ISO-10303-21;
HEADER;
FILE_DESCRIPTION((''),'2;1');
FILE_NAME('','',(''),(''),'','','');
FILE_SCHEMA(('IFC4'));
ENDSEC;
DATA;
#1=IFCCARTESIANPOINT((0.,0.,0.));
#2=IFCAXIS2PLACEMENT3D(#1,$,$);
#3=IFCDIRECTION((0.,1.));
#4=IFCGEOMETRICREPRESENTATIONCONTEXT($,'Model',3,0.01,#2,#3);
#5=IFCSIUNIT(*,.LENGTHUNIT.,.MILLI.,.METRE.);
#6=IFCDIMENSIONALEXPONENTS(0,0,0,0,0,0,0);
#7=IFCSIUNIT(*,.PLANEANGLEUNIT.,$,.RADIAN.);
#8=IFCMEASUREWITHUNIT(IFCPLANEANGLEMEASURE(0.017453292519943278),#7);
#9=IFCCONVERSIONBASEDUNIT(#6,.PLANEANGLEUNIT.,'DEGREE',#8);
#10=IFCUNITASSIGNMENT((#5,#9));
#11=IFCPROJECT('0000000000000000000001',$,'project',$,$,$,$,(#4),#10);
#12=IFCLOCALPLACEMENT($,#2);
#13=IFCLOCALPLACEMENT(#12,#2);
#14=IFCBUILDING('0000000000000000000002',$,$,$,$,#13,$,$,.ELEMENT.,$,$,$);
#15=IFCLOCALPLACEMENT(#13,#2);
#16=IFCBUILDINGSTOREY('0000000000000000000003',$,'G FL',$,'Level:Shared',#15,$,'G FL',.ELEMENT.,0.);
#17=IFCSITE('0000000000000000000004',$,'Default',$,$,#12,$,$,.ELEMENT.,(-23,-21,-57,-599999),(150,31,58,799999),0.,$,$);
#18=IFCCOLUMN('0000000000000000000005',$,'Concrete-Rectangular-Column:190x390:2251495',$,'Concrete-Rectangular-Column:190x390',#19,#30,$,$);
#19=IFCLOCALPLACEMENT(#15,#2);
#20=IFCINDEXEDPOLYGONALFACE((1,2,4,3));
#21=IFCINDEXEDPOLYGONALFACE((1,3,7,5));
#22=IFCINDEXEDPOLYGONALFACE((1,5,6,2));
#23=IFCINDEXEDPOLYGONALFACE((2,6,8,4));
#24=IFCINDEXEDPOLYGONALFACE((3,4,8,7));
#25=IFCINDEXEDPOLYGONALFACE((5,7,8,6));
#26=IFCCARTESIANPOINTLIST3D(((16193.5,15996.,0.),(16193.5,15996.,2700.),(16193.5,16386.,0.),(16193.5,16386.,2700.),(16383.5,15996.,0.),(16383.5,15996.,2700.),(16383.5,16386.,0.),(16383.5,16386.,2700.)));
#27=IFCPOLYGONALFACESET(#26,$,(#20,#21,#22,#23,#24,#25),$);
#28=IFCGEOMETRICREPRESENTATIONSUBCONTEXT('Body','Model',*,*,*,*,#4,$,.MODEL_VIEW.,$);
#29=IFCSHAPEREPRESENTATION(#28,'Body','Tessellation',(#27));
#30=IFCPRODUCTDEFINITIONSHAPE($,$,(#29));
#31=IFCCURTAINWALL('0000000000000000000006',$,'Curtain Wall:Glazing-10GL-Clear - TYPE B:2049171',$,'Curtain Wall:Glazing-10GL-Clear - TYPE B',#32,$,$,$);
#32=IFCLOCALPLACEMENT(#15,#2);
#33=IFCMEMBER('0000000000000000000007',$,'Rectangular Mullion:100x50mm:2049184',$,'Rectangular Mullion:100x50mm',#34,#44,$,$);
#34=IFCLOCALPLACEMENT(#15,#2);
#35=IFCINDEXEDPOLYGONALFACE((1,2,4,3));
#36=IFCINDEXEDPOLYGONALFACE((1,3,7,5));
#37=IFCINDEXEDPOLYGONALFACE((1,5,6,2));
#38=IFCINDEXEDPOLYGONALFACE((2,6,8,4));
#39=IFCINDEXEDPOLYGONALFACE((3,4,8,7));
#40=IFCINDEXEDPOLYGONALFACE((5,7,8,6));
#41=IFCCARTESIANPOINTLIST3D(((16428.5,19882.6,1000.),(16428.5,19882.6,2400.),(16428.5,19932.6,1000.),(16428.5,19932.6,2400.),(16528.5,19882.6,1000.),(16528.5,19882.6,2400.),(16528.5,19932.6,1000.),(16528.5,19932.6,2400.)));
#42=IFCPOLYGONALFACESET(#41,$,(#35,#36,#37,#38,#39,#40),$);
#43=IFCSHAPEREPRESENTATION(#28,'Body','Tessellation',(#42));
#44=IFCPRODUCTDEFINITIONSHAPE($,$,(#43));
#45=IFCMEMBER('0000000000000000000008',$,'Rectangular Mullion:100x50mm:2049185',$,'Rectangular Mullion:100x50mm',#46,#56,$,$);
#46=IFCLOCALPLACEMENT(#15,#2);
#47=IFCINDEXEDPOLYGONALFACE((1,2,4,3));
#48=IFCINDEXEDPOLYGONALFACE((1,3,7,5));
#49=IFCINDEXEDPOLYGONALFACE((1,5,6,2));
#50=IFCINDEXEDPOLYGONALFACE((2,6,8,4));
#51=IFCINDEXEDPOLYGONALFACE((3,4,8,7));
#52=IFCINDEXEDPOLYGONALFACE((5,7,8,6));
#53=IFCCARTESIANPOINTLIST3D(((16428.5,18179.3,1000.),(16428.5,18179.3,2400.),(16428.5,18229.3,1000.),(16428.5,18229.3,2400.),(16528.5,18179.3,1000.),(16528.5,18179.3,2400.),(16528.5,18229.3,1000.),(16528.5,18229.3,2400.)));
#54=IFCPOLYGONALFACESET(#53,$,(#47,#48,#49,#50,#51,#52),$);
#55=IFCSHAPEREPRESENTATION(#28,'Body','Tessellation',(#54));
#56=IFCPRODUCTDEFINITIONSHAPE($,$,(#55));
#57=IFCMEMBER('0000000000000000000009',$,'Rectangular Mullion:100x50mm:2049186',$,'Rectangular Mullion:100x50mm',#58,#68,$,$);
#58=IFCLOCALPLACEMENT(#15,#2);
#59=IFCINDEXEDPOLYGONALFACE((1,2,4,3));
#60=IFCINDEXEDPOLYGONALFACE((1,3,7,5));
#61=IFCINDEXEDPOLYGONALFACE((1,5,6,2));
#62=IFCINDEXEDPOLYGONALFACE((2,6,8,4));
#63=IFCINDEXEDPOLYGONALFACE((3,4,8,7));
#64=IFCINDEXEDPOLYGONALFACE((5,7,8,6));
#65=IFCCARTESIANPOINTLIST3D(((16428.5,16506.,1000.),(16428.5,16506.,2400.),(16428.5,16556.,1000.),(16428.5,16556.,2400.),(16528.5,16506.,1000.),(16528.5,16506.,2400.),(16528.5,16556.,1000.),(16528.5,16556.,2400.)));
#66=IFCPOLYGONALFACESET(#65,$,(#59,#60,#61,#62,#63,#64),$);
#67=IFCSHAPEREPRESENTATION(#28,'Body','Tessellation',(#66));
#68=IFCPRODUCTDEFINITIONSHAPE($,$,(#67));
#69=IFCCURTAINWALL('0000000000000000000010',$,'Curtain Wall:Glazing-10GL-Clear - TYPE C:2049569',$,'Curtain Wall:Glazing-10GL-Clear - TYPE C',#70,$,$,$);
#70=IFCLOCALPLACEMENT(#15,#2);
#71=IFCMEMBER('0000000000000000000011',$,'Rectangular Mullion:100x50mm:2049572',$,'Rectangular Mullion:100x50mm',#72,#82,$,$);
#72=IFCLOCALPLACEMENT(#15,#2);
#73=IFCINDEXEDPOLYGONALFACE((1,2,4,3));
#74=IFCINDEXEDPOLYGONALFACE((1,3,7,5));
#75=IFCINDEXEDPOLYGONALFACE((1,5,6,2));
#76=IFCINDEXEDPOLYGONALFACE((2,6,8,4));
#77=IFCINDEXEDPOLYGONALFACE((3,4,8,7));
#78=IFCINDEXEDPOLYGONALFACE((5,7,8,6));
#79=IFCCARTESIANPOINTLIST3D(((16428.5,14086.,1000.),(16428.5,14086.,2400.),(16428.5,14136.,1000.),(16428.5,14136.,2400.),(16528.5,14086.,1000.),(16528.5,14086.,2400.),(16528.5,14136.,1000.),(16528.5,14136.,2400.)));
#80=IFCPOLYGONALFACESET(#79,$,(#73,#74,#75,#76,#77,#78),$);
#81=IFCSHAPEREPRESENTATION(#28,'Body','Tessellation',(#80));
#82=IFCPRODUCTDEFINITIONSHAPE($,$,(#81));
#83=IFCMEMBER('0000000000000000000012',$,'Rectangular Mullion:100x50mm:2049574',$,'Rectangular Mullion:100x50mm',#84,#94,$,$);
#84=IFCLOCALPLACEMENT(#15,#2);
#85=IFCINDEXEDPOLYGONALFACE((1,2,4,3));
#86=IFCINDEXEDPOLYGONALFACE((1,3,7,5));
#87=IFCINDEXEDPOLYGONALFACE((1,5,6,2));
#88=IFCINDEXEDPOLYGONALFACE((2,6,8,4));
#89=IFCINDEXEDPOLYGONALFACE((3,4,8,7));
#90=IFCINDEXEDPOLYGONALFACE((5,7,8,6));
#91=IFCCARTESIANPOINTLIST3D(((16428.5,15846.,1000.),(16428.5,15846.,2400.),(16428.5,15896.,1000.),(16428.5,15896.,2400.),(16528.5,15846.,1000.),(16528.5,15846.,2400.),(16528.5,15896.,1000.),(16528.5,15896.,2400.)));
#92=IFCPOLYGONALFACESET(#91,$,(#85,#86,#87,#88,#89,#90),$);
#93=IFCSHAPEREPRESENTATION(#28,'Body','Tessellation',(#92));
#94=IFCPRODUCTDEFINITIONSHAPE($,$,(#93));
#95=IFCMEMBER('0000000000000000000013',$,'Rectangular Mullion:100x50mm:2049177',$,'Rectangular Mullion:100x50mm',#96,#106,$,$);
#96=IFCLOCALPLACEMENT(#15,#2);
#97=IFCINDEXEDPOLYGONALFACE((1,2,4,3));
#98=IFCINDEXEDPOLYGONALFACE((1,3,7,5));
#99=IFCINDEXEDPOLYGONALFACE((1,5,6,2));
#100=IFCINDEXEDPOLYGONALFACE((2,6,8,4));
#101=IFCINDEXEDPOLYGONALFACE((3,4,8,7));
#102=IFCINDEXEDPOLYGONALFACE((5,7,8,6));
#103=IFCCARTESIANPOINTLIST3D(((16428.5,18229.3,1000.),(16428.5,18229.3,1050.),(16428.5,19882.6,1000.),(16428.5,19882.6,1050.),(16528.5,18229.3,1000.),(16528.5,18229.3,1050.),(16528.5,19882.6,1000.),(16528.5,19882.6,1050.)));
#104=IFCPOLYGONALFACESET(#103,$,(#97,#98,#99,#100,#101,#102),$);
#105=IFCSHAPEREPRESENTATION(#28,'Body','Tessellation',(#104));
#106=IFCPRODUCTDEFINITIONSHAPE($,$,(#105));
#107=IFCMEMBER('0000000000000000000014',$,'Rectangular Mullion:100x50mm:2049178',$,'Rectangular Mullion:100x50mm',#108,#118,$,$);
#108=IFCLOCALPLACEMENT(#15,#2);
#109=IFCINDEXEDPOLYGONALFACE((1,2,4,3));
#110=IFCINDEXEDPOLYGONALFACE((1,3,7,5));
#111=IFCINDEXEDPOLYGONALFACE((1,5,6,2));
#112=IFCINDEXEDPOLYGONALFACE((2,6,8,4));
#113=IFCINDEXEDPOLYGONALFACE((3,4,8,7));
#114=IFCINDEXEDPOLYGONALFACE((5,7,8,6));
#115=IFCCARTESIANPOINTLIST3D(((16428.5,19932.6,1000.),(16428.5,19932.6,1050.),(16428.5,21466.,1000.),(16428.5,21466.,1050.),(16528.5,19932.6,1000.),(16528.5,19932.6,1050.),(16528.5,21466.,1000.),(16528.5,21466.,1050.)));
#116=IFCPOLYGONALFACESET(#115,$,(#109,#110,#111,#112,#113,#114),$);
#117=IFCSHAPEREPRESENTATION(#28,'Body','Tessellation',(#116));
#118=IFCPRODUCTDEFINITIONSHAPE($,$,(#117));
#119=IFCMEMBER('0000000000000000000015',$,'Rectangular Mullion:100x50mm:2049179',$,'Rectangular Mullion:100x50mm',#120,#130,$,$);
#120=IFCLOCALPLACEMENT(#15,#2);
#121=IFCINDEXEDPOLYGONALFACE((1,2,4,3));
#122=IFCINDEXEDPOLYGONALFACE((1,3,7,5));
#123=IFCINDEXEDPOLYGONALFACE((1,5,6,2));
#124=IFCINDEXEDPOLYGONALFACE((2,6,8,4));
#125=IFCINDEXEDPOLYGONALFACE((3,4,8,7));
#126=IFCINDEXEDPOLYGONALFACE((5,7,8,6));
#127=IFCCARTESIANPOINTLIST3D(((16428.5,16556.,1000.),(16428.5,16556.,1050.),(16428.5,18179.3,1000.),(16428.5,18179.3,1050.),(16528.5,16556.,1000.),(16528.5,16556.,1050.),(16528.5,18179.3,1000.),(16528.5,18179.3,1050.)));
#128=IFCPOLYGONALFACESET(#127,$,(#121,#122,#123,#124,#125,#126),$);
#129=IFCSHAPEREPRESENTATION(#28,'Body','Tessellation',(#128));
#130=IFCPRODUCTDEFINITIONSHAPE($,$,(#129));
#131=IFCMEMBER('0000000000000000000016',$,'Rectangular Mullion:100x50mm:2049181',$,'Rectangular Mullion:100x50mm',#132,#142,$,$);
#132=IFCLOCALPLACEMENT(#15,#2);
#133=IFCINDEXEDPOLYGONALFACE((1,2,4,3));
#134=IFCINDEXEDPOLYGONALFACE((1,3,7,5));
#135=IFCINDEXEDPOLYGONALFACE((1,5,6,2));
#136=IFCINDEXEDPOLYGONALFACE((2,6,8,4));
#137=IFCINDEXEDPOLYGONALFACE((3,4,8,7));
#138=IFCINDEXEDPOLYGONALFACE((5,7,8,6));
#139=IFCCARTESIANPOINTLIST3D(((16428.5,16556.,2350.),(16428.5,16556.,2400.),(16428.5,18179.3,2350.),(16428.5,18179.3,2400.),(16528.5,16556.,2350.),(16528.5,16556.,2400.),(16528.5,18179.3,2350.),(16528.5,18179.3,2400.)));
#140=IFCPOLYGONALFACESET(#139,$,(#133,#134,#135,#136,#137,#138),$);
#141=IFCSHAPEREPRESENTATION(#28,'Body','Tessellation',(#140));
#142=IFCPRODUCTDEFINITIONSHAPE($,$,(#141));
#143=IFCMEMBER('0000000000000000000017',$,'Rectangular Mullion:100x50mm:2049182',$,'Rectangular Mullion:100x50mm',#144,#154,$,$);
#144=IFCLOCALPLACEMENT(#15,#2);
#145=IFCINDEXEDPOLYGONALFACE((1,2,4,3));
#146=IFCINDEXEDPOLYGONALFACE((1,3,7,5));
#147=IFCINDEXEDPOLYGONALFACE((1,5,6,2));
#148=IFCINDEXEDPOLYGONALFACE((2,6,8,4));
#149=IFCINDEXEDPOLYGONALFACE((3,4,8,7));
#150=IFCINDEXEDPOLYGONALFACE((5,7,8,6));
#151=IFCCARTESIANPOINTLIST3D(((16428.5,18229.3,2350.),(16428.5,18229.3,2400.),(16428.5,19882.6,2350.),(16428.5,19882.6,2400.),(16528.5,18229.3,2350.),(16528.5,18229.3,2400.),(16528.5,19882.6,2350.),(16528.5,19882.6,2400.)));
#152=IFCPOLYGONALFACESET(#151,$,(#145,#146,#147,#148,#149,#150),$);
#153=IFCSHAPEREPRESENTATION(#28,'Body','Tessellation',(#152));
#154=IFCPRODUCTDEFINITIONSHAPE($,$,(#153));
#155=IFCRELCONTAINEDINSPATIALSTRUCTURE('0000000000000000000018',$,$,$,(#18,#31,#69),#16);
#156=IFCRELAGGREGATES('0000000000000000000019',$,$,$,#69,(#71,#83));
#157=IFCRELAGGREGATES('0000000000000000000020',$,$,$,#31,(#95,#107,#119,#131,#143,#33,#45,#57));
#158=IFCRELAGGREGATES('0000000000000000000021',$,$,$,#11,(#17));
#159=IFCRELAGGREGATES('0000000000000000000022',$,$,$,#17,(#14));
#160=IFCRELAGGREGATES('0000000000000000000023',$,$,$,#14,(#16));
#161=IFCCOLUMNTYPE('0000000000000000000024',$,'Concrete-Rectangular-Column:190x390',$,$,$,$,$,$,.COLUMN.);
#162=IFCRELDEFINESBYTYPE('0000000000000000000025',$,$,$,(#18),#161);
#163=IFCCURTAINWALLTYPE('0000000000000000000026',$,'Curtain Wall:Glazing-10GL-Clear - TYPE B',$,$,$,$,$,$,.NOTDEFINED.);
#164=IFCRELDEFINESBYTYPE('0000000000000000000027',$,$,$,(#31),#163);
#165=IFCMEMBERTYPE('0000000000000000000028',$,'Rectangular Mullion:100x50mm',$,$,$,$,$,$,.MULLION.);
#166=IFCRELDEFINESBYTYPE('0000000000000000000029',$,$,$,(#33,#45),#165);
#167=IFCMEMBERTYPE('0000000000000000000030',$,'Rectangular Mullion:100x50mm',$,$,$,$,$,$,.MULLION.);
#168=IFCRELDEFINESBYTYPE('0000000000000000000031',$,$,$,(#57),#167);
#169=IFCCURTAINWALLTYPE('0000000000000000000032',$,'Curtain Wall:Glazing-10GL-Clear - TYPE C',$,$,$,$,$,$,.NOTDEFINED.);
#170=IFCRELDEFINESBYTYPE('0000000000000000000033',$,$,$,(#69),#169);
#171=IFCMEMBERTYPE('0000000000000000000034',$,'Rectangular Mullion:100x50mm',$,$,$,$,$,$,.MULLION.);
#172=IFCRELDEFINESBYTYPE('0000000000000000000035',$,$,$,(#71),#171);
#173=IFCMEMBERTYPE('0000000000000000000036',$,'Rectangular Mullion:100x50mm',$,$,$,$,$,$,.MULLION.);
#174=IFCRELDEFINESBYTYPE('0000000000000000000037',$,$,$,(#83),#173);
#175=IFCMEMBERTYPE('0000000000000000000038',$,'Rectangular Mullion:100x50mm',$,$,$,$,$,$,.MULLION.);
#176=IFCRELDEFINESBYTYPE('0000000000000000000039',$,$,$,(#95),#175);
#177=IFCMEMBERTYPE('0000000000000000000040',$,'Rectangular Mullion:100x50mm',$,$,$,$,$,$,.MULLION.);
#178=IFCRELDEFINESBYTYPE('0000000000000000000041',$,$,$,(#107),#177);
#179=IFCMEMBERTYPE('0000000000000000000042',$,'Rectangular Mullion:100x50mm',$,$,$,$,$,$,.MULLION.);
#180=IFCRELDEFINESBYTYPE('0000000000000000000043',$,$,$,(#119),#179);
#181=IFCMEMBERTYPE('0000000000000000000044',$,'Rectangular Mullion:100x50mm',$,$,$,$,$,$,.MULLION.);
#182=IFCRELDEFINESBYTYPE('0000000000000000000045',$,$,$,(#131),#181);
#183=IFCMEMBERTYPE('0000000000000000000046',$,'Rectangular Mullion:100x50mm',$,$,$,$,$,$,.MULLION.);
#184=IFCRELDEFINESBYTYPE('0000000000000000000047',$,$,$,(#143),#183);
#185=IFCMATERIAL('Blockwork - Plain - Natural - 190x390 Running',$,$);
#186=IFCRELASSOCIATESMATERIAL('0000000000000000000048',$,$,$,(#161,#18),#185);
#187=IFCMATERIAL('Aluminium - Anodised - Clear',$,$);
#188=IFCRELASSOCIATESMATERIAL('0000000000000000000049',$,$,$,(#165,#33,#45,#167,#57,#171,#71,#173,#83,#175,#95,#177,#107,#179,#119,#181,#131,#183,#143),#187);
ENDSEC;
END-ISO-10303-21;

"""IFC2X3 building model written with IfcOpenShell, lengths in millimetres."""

from ifc_helpers import new_model, entity, si_unit, converted_unit, direction, frame, frame_2d, origin, origin_2d_with_axis, place, context, subcontext, project, spatial, rectangle, extrude, source, transform, mapped, material, type_object, type_shapes, element, aggregate, save


model = new_model("IFC2X3")

# Units and contexts
model_context = context("Model", 3, precision=0.01, world=origin(), true_north=direction((0.0, 1.0)))
body_context = subcontext(model_context, "Body", "Model", "MODEL_VIEW")
ifc_project = project(units=[si_unit("LENGTHUNIT", "METRE", prefix="MILLI"), converted_unit("PLANEANGLEUNIT", "DEGREE", entity("IfcPlaneAngleMeasure", 0.017453292519943278), si_unit("PLANEANGLEUNIT", "RADIAN"), dimensions=[0, 0, 0, 0, 0, 0, 0])], contexts=[model_context])

# Site, building, storey
site_placement = place(None, origin())
site = spatial("IfcSite", under=ifc_project, at=site_placement, Name="Default", CompositionType="ELEMENT", RefLatitude=(-23, -21, -57, -599999), RefLongitude=(150, 31, 58, 799999), RefElevation=0.0)
building_placement = place(site_placement, origin())
building = spatial("IfcBuilding", under=site, at=building_placement, CompositionType="ELEMENT")
storey_placement = place(building_placement, origin())
storey = spatial("IfcBuildingStorey", under=building, at=storey_placement, Name="G FL", ObjectType="Level:Shared", LongName="G FL", CompositionType="ELEMENT", Elevation=0.0)

# Column
ifc_material_1 = material(Name="Blockwork - Plain - Natural - 190x390 Running")
column_type = type_object("IfcColumnType", Name="Concrete-Rectangular-Column:190x390", PredefinedType="COLUMN", material=ifc_material_1)
shared_shape_1 = source(origin(), body_context, "Body", "SweptSolid", [
    extrude(rectangle(XDim=190.0, YDim=390.0, at=origin_2d_with_axis()), frame((0.0, 0.0, 0.0), z_axis=(0.0, 0.0, 1.0), x_axis=(-1.0, 0.0, 0.0)), (0.0, 0.0, 1.0), 2700.0),
])
type_shapes(column_type, [shared_shape_1])
column_placement = place(storey_placement, frame((16288.5, 16191.0, 0.0)))
element("IfcColumn", 1, at=column_placement, inside=storey, type_object=column_type, material=ifc_material_1, Name="Concrete-Rectangular-Column:190x390:2251495", ObjectType="Concrete-Rectangular-Column:190x390", context=body_context, shape_type="MappedRepresentation", body=[
    mapped(shared_shape_1, transform((0.0, 0.0, 0.0), scale=1.0)),
])

# Curtain walls, members
curtain_wall_type_1 = type_object("IfcCurtainWallType", Name="Curtain Wall:Glazing-10GL-Clear - TYPE B", PredefinedType="NOTDEFINED")
curtain_wall_1_placement = place(storey_placement, origin())
curtain_wall_1 = element("IfcCurtainWall", 2, at=curtain_wall_1_placement, inside=storey, type_object=curtain_wall_type_1, Name="Curtain Wall:Glazing-10GL-Clear - TYPE B:2049171", ObjectType="Curtain Wall:Glazing-10GL-Clear - TYPE B")
ifc_material_2 = material(Name="Aluminium - Anodised - Clear")
member_type_1 = type_object("IfcMemberType", Name="Rectangular Mullion:100x50mm", PredefinedType="MULLION", material=ifc_material_2)
shared_shape_2 = source(origin(), body_context, "Body", "SweptSolid", [
    extrude(rectangle(XDim=50.0, YDim=100.0, at=frame_2d((0.0, 0.0), x_axis=(1.0, 0.0))), frame((0.0, 0.0, -1400.0), z_axis=(0.0, 0.0, 1.0), x_axis=(-1.0, 0.0, 0.0)), (0.0, 0.0, 1.0), 1400.0),
])
type_shapes(member_type_1, [shared_shape_2])
member_1_placement = place(curtain_wall_1_placement, frame((16478.5, 19907.6, 1000.0), z_axis=(0.0, 0.0, -1.0), x_axis=(0.0, 1.0, 0.0)))
member_1 = element("IfcMember", 3, at=member_1_placement, type_object=member_type_1, material=ifc_material_2, Name="Rectangular Mullion:100x50mm:2049184", ObjectType="Rectangular Mullion:100x50mm", context=body_context, shape_type="MappedRepresentation", body=[
    mapped(shared_shape_2, transform((0.0, 0.0, 0.0), scale=1.0)),
])
member_2_placement = place(curtain_wall_1_placement, frame((16478.5, 18204.3, 1000.0), z_axis=(0.0, 0.0, -1.0), x_axis=(0.0, 1.0, 0.0)))
member_2 = element("IfcMember", 4, at=member_2_placement, type_object=member_type_1, material=ifc_material_2, Name="Rectangular Mullion:100x50mm:2049185", ObjectType="Rectangular Mullion:100x50mm", context=body_context, shape_type="MappedRepresentation", body=[
    mapped(shared_shape_2, transform((0.0, 0.0, 0.0), scale=1.0)),
])
member_type_2 = type_object("IfcMemberType", Name="Rectangular Mullion:100x50mm", PredefinedType="MULLION", material=ifc_material_2)
shared_shape_3 = source(origin(), body_context, "Body", "SweptSolid", [
    extrude(rectangle(XDim=50.0, YDim=100.0, at=frame_2d((0.0, 0.0), x_axis=(1.0, 0.0))), frame((-25.0, 0.0, -1400.0), z_axis=(0.0, 0.0, 1.0), x_axis=(-1.0, 0.0, 0.0)), (0.0, 0.0, 1.0), 1400.0),
])
type_shapes(member_type_2, [shared_shape_3])
member_3_placement = place(curtain_wall_1_placement, frame((16478.5, 16506.0, 2400.0), z_axis=(0.0, 0.0, 1.0), x_axis=(0.0, -1.0, 0.0)))
member_3 = element("IfcMember", 5, at=member_3_placement, type_object=member_type_2, material=ifc_material_2, Name="Rectangular Mullion:100x50mm:2049186", ObjectType="Rectangular Mullion:100x50mm", context=body_context, shape_type="MappedRepresentation", body=[
    mapped(shared_shape_3, transform((0.0, 0.0, 0.0), scale=1.0)),
])
curtain_wall_type_2 = type_object("IfcCurtainWallType", Name="Curtain Wall:Glazing-10GL-Clear - TYPE C", PredefinedType="NOTDEFINED")
curtain_wall_2_placement = place(storey_placement, origin())
curtain_wall_2 = element("IfcCurtainWall", 6, at=curtain_wall_2_placement, inside=storey, type_object=curtain_wall_type_2, Name="Curtain Wall:Glazing-10GL-Clear - TYPE C:2049569", ObjectType="Curtain Wall:Glazing-10GL-Clear - TYPE C")
member_type_3 = type_object("IfcMemberType", Name="Rectangular Mullion:100x50mm", PredefinedType="MULLION", material=ifc_material_2)
shared_shape_4 = source(origin(), body_context, "Body", "SweptSolid", [
    extrude(rectangle(XDim=50.0, YDim=100.0, at=frame_2d((0.0, 0.0), x_axis=(1.0, 0.0))), frame((-25.0, 0.0, -1400.0), z_axis=(0.0, 0.0, 1.0), x_axis=(-1.0, 0.0, 0.0)), (0.0, 0.0, 1.0), 1400.0),
])
type_shapes(member_type_3, [shared_shape_4])
member_4_placement = place(curtain_wall_2_placement, frame((16478.5, 14086.0, 1000.0), z_axis=(0.0, 0.0, -1.0), x_axis=(0.0, -1.0, 0.0)))
member_4 = element("IfcMember", 7, at=member_4_placement, type_object=member_type_3, material=ifc_material_2, Name="Rectangular Mullion:100x50mm:2049572", ObjectType="Rectangular Mullion:100x50mm", context=body_context, shape_type="MappedRepresentation", body=[
    mapped(shared_shape_4, transform((0.0, 0.0, 0.0), scale=1.0)),
])
member_type_4 = type_object("IfcMemberType", Name="Rectangular Mullion:100x50mm", PredefinedType="MULLION", material=ifc_material_2)
shared_shape_5 = source(origin(), body_context, "Body", "SweptSolid", [
    extrude(rectangle(XDim=50.0, YDim=100.0, at=origin_2d_with_axis()), frame((-25.0, 0.0, -1400.0), z_axis=(0.0, 0.0, 1.0), x_axis=(-1.0, 0.0, 0.0)), (0.0, 0.0, 1.0), 1400.0),
])
type_shapes(member_type_4, [shared_shape_5])
member_5_placement = place(curtain_wall_2_placement, frame((16478.5, 15896.0, 2400.0), z_axis=(0.0, 0.0, 1.0), x_axis=(0.0, 1.0, 0.0)))
member_5 = element("IfcMember", 8, at=member_5_placement, type_object=member_type_4, material=ifc_material_2, Name="Rectangular Mullion:100x50mm:2049574", ObjectType="Rectangular Mullion:100x50mm", context=body_context, shape_type="MappedRepresentation", body=[
    mapped(shared_shape_5, transform((0.0, 0.0, 0.0), scale=1.0)),
])

# Members
member_type_5 = type_object("IfcMemberType", Name="Rectangular Mullion:100x50mm", PredefinedType="MULLION", material=ifc_material_2)
shared_shape_6 = source(origin(), body_context, "Body", "SweptSolid", [
    extrude(rectangle(XDim=50.0, YDim=100.0, at=frame_2d((0.0, 0.0), x_axis=(1.0, 0.0))), frame((-25.0, 0.0, -1653.3), z_axis=(0.0, 0.0, 1.0), x_axis=(-1.0, 0.0, 0.0)), (0.0, 0.0, 1.0), 1653.3),
])
type_shapes(member_type_5, [shared_shape_6])
member_6_placement = place(curtain_wall_1_placement, frame((16478.5, 18229.3, 1000.0), z_axis=(0.0, -1.0, 0.0), x_axis=(0.0, 0.0, -1.0)))
member_6 = element("IfcMember", 9, at=member_6_placement, type_object=member_type_5, material=ifc_material_2, Name="Rectangular Mullion:100x50mm:2049177", ObjectType="Rectangular Mullion:100x50mm", context=body_context, shape_type="MappedRepresentation", body=[
    mapped(shared_shape_6, transform((0.0, 0.0, 0.0), scale=1.0)),
])
member_type_6 = type_object("IfcMemberType", Name="Rectangular Mullion:100x50mm", PredefinedType="MULLION", material=ifc_material_2)
shared_shape_7 = source(origin(), body_context, "Body", "SweptSolid", [
    extrude(rectangle(XDim=50.0, YDim=100.0, at=frame_2d((0.0, 0.0), x_axis=(1.0, 0.0))), frame((-25.0, 0.0, -1533.3), z_axis=(0.0, 0.0, 1.0), x_axis=(-1.0, 0.0, 0.0)), (0.0, 0.0, 1.0), 1533.3),
])
type_shapes(member_type_6, [shared_shape_7])
member_7_placement = place(curtain_wall_1_placement, frame((16478.5, 19932.6, 1000.0), z_axis=(0.0, -1.0, 0.0), x_axis=(0.0, 0.0, -1.0)))
member_7 = element("IfcMember", 10, at=member_7_placement, type_object=member_type_6, material=ifc_material_2, Name="Rectangular Mullion:100x50mm:2049178", ObjectType="Rectangular Mullion:100x50mm", context=body_context, shape_type="MappedRepresentation", body=[
    mapped(shared_shape_7, transform((0.0, 0.0, 0.0), scale=1.0)),
])
member_type_7 = type_object("IfcMemberType", Name="Rectangular Mullion:100x50mm", PredefinedType="MULLION", material=ifc_material_2)
shared_shape_8 = source(origin(), body_context, "Body", "SweptSolid", [
    extrude(rectangle(XDim=50.0, YDim=100.0, at=origin_2d_with_axis()), frame((-25.0, 0.0, -1623.3), z_axis=(0.0, 0.0, 1.0), x_axis=(-1.0, 0.0, 0.0)), (0.0, 0.0, 1.0), 1623.3),
])
type_shapes(member_type_7, [shared_shape_8])
member_8_placement = place(curtain_wall_1_placement, frame((16478.5, 16556.0, 1000.0), z_axis=(0.0, -1.0, 0.0), x_axis=(0.0, 0.0, -1.0)))
member_8 = element("IfcMember", 11, at=member_8_placement, type_object=member_type_7, material=ifc_material_2, Name="Rectangular Mullion:100x50mm:2049179", ObjectType="Rectangular Mullion:100x50mm", context=body_context, shape_type="MappedRepresentation", body=[
    mapped(shared_shape_8, transform((0.0, 0.0, 0.0), scale=1.0)),
])
member_type_8 = type_object("IfcMemberType", Name="Rectangular Mullion:100x50mm", PredefinedType="MULLION", material=ifc_material_2)
shared_shape_9 = source(origin(), body_context, "Body", "SweptSolid", [
    extrude(rectangle(XDim=50.0, YDim=100.0, at=origin_2d_with_axis()), frame((-25.0, 0.0, -1623.3), z_axis=(0.0, 0.0, 1.0), x_axis=(-1.0, 0.0, 0.0)), (0.0, 0.0, 1.0), 1623.3),
])
type_shapes(member_type_8, [shared_shape_9])
member_9_placement = place(curtain_wall_1_placement, frame((16478.5, 18179.3, 2400.0), z_axis=(0.0, 1.0, 0.0), x_axis=(0.0, 0.0, 1.0)))
member_9 = element("IfcMember", 12, at=member_9_placement, type_object=member_type_8, material=ifc_material_2, Name="Rectangular Mullion:100x50mm:2049181", ObjectType="Rectangular Mullion:100x50mm", context=body_context, shape_type="MappedRepresentation", body=[
    mapped(shared_shape_9, transform((0.0, 0.0, 0.0), scale=1.0)),
])
member_type_9 = type_object("IfcMemberType", Name="Rectangular Mullion:100x50mm", PredefinedType="MULLION", material=ifc_material_2)
shared_shape_10 = source(origin(), body_context, "Body", "SweptSolid", [
    extrude(rectangle(XDim=50.0, YDim=100.0, at=frame_2d((0.0, 0.0), x_axis=(1.0, 0.0))), frame((-25.0, 0.0, -1653.3), z_axis=(0.0, 0.0, 1.0), x_axis=(-1.0, 0.0, 0.0)), (0.0, 0.0, 1.0), 1653.3),
])
type_shapes(member_type_9, [shared_shape_10])
member_10_placement = place(curtain_wall_1_placement, frame((16478.5, 19882.6, 2400.0), z_axis=(0.0, 1.0, 0.0), x_axis=(0.0, 0.0, 1.0)))
member_10 = element("IfcMember", 13, at=member_10_placement, type_object=member_type_9, material=ifc_material_2, Name="Rectangular Mullion:100x50mm:2049182", ObjectType="Rectangular Mullion:100x50mm", context=body_context, shape_type="MappedRepresentation", body=[
    mapped(shared_shape_10, transform((0.0, 0.0, 0.0), scale=1.0)),
])
aggregate(curtain_wall_2, [member_4, member_5])

aggregate(curtain_wall_1, [member_6, member_7, member_8, member_9, member_10, member_1, member_2, member_3])

save(model, "model.ifc")
